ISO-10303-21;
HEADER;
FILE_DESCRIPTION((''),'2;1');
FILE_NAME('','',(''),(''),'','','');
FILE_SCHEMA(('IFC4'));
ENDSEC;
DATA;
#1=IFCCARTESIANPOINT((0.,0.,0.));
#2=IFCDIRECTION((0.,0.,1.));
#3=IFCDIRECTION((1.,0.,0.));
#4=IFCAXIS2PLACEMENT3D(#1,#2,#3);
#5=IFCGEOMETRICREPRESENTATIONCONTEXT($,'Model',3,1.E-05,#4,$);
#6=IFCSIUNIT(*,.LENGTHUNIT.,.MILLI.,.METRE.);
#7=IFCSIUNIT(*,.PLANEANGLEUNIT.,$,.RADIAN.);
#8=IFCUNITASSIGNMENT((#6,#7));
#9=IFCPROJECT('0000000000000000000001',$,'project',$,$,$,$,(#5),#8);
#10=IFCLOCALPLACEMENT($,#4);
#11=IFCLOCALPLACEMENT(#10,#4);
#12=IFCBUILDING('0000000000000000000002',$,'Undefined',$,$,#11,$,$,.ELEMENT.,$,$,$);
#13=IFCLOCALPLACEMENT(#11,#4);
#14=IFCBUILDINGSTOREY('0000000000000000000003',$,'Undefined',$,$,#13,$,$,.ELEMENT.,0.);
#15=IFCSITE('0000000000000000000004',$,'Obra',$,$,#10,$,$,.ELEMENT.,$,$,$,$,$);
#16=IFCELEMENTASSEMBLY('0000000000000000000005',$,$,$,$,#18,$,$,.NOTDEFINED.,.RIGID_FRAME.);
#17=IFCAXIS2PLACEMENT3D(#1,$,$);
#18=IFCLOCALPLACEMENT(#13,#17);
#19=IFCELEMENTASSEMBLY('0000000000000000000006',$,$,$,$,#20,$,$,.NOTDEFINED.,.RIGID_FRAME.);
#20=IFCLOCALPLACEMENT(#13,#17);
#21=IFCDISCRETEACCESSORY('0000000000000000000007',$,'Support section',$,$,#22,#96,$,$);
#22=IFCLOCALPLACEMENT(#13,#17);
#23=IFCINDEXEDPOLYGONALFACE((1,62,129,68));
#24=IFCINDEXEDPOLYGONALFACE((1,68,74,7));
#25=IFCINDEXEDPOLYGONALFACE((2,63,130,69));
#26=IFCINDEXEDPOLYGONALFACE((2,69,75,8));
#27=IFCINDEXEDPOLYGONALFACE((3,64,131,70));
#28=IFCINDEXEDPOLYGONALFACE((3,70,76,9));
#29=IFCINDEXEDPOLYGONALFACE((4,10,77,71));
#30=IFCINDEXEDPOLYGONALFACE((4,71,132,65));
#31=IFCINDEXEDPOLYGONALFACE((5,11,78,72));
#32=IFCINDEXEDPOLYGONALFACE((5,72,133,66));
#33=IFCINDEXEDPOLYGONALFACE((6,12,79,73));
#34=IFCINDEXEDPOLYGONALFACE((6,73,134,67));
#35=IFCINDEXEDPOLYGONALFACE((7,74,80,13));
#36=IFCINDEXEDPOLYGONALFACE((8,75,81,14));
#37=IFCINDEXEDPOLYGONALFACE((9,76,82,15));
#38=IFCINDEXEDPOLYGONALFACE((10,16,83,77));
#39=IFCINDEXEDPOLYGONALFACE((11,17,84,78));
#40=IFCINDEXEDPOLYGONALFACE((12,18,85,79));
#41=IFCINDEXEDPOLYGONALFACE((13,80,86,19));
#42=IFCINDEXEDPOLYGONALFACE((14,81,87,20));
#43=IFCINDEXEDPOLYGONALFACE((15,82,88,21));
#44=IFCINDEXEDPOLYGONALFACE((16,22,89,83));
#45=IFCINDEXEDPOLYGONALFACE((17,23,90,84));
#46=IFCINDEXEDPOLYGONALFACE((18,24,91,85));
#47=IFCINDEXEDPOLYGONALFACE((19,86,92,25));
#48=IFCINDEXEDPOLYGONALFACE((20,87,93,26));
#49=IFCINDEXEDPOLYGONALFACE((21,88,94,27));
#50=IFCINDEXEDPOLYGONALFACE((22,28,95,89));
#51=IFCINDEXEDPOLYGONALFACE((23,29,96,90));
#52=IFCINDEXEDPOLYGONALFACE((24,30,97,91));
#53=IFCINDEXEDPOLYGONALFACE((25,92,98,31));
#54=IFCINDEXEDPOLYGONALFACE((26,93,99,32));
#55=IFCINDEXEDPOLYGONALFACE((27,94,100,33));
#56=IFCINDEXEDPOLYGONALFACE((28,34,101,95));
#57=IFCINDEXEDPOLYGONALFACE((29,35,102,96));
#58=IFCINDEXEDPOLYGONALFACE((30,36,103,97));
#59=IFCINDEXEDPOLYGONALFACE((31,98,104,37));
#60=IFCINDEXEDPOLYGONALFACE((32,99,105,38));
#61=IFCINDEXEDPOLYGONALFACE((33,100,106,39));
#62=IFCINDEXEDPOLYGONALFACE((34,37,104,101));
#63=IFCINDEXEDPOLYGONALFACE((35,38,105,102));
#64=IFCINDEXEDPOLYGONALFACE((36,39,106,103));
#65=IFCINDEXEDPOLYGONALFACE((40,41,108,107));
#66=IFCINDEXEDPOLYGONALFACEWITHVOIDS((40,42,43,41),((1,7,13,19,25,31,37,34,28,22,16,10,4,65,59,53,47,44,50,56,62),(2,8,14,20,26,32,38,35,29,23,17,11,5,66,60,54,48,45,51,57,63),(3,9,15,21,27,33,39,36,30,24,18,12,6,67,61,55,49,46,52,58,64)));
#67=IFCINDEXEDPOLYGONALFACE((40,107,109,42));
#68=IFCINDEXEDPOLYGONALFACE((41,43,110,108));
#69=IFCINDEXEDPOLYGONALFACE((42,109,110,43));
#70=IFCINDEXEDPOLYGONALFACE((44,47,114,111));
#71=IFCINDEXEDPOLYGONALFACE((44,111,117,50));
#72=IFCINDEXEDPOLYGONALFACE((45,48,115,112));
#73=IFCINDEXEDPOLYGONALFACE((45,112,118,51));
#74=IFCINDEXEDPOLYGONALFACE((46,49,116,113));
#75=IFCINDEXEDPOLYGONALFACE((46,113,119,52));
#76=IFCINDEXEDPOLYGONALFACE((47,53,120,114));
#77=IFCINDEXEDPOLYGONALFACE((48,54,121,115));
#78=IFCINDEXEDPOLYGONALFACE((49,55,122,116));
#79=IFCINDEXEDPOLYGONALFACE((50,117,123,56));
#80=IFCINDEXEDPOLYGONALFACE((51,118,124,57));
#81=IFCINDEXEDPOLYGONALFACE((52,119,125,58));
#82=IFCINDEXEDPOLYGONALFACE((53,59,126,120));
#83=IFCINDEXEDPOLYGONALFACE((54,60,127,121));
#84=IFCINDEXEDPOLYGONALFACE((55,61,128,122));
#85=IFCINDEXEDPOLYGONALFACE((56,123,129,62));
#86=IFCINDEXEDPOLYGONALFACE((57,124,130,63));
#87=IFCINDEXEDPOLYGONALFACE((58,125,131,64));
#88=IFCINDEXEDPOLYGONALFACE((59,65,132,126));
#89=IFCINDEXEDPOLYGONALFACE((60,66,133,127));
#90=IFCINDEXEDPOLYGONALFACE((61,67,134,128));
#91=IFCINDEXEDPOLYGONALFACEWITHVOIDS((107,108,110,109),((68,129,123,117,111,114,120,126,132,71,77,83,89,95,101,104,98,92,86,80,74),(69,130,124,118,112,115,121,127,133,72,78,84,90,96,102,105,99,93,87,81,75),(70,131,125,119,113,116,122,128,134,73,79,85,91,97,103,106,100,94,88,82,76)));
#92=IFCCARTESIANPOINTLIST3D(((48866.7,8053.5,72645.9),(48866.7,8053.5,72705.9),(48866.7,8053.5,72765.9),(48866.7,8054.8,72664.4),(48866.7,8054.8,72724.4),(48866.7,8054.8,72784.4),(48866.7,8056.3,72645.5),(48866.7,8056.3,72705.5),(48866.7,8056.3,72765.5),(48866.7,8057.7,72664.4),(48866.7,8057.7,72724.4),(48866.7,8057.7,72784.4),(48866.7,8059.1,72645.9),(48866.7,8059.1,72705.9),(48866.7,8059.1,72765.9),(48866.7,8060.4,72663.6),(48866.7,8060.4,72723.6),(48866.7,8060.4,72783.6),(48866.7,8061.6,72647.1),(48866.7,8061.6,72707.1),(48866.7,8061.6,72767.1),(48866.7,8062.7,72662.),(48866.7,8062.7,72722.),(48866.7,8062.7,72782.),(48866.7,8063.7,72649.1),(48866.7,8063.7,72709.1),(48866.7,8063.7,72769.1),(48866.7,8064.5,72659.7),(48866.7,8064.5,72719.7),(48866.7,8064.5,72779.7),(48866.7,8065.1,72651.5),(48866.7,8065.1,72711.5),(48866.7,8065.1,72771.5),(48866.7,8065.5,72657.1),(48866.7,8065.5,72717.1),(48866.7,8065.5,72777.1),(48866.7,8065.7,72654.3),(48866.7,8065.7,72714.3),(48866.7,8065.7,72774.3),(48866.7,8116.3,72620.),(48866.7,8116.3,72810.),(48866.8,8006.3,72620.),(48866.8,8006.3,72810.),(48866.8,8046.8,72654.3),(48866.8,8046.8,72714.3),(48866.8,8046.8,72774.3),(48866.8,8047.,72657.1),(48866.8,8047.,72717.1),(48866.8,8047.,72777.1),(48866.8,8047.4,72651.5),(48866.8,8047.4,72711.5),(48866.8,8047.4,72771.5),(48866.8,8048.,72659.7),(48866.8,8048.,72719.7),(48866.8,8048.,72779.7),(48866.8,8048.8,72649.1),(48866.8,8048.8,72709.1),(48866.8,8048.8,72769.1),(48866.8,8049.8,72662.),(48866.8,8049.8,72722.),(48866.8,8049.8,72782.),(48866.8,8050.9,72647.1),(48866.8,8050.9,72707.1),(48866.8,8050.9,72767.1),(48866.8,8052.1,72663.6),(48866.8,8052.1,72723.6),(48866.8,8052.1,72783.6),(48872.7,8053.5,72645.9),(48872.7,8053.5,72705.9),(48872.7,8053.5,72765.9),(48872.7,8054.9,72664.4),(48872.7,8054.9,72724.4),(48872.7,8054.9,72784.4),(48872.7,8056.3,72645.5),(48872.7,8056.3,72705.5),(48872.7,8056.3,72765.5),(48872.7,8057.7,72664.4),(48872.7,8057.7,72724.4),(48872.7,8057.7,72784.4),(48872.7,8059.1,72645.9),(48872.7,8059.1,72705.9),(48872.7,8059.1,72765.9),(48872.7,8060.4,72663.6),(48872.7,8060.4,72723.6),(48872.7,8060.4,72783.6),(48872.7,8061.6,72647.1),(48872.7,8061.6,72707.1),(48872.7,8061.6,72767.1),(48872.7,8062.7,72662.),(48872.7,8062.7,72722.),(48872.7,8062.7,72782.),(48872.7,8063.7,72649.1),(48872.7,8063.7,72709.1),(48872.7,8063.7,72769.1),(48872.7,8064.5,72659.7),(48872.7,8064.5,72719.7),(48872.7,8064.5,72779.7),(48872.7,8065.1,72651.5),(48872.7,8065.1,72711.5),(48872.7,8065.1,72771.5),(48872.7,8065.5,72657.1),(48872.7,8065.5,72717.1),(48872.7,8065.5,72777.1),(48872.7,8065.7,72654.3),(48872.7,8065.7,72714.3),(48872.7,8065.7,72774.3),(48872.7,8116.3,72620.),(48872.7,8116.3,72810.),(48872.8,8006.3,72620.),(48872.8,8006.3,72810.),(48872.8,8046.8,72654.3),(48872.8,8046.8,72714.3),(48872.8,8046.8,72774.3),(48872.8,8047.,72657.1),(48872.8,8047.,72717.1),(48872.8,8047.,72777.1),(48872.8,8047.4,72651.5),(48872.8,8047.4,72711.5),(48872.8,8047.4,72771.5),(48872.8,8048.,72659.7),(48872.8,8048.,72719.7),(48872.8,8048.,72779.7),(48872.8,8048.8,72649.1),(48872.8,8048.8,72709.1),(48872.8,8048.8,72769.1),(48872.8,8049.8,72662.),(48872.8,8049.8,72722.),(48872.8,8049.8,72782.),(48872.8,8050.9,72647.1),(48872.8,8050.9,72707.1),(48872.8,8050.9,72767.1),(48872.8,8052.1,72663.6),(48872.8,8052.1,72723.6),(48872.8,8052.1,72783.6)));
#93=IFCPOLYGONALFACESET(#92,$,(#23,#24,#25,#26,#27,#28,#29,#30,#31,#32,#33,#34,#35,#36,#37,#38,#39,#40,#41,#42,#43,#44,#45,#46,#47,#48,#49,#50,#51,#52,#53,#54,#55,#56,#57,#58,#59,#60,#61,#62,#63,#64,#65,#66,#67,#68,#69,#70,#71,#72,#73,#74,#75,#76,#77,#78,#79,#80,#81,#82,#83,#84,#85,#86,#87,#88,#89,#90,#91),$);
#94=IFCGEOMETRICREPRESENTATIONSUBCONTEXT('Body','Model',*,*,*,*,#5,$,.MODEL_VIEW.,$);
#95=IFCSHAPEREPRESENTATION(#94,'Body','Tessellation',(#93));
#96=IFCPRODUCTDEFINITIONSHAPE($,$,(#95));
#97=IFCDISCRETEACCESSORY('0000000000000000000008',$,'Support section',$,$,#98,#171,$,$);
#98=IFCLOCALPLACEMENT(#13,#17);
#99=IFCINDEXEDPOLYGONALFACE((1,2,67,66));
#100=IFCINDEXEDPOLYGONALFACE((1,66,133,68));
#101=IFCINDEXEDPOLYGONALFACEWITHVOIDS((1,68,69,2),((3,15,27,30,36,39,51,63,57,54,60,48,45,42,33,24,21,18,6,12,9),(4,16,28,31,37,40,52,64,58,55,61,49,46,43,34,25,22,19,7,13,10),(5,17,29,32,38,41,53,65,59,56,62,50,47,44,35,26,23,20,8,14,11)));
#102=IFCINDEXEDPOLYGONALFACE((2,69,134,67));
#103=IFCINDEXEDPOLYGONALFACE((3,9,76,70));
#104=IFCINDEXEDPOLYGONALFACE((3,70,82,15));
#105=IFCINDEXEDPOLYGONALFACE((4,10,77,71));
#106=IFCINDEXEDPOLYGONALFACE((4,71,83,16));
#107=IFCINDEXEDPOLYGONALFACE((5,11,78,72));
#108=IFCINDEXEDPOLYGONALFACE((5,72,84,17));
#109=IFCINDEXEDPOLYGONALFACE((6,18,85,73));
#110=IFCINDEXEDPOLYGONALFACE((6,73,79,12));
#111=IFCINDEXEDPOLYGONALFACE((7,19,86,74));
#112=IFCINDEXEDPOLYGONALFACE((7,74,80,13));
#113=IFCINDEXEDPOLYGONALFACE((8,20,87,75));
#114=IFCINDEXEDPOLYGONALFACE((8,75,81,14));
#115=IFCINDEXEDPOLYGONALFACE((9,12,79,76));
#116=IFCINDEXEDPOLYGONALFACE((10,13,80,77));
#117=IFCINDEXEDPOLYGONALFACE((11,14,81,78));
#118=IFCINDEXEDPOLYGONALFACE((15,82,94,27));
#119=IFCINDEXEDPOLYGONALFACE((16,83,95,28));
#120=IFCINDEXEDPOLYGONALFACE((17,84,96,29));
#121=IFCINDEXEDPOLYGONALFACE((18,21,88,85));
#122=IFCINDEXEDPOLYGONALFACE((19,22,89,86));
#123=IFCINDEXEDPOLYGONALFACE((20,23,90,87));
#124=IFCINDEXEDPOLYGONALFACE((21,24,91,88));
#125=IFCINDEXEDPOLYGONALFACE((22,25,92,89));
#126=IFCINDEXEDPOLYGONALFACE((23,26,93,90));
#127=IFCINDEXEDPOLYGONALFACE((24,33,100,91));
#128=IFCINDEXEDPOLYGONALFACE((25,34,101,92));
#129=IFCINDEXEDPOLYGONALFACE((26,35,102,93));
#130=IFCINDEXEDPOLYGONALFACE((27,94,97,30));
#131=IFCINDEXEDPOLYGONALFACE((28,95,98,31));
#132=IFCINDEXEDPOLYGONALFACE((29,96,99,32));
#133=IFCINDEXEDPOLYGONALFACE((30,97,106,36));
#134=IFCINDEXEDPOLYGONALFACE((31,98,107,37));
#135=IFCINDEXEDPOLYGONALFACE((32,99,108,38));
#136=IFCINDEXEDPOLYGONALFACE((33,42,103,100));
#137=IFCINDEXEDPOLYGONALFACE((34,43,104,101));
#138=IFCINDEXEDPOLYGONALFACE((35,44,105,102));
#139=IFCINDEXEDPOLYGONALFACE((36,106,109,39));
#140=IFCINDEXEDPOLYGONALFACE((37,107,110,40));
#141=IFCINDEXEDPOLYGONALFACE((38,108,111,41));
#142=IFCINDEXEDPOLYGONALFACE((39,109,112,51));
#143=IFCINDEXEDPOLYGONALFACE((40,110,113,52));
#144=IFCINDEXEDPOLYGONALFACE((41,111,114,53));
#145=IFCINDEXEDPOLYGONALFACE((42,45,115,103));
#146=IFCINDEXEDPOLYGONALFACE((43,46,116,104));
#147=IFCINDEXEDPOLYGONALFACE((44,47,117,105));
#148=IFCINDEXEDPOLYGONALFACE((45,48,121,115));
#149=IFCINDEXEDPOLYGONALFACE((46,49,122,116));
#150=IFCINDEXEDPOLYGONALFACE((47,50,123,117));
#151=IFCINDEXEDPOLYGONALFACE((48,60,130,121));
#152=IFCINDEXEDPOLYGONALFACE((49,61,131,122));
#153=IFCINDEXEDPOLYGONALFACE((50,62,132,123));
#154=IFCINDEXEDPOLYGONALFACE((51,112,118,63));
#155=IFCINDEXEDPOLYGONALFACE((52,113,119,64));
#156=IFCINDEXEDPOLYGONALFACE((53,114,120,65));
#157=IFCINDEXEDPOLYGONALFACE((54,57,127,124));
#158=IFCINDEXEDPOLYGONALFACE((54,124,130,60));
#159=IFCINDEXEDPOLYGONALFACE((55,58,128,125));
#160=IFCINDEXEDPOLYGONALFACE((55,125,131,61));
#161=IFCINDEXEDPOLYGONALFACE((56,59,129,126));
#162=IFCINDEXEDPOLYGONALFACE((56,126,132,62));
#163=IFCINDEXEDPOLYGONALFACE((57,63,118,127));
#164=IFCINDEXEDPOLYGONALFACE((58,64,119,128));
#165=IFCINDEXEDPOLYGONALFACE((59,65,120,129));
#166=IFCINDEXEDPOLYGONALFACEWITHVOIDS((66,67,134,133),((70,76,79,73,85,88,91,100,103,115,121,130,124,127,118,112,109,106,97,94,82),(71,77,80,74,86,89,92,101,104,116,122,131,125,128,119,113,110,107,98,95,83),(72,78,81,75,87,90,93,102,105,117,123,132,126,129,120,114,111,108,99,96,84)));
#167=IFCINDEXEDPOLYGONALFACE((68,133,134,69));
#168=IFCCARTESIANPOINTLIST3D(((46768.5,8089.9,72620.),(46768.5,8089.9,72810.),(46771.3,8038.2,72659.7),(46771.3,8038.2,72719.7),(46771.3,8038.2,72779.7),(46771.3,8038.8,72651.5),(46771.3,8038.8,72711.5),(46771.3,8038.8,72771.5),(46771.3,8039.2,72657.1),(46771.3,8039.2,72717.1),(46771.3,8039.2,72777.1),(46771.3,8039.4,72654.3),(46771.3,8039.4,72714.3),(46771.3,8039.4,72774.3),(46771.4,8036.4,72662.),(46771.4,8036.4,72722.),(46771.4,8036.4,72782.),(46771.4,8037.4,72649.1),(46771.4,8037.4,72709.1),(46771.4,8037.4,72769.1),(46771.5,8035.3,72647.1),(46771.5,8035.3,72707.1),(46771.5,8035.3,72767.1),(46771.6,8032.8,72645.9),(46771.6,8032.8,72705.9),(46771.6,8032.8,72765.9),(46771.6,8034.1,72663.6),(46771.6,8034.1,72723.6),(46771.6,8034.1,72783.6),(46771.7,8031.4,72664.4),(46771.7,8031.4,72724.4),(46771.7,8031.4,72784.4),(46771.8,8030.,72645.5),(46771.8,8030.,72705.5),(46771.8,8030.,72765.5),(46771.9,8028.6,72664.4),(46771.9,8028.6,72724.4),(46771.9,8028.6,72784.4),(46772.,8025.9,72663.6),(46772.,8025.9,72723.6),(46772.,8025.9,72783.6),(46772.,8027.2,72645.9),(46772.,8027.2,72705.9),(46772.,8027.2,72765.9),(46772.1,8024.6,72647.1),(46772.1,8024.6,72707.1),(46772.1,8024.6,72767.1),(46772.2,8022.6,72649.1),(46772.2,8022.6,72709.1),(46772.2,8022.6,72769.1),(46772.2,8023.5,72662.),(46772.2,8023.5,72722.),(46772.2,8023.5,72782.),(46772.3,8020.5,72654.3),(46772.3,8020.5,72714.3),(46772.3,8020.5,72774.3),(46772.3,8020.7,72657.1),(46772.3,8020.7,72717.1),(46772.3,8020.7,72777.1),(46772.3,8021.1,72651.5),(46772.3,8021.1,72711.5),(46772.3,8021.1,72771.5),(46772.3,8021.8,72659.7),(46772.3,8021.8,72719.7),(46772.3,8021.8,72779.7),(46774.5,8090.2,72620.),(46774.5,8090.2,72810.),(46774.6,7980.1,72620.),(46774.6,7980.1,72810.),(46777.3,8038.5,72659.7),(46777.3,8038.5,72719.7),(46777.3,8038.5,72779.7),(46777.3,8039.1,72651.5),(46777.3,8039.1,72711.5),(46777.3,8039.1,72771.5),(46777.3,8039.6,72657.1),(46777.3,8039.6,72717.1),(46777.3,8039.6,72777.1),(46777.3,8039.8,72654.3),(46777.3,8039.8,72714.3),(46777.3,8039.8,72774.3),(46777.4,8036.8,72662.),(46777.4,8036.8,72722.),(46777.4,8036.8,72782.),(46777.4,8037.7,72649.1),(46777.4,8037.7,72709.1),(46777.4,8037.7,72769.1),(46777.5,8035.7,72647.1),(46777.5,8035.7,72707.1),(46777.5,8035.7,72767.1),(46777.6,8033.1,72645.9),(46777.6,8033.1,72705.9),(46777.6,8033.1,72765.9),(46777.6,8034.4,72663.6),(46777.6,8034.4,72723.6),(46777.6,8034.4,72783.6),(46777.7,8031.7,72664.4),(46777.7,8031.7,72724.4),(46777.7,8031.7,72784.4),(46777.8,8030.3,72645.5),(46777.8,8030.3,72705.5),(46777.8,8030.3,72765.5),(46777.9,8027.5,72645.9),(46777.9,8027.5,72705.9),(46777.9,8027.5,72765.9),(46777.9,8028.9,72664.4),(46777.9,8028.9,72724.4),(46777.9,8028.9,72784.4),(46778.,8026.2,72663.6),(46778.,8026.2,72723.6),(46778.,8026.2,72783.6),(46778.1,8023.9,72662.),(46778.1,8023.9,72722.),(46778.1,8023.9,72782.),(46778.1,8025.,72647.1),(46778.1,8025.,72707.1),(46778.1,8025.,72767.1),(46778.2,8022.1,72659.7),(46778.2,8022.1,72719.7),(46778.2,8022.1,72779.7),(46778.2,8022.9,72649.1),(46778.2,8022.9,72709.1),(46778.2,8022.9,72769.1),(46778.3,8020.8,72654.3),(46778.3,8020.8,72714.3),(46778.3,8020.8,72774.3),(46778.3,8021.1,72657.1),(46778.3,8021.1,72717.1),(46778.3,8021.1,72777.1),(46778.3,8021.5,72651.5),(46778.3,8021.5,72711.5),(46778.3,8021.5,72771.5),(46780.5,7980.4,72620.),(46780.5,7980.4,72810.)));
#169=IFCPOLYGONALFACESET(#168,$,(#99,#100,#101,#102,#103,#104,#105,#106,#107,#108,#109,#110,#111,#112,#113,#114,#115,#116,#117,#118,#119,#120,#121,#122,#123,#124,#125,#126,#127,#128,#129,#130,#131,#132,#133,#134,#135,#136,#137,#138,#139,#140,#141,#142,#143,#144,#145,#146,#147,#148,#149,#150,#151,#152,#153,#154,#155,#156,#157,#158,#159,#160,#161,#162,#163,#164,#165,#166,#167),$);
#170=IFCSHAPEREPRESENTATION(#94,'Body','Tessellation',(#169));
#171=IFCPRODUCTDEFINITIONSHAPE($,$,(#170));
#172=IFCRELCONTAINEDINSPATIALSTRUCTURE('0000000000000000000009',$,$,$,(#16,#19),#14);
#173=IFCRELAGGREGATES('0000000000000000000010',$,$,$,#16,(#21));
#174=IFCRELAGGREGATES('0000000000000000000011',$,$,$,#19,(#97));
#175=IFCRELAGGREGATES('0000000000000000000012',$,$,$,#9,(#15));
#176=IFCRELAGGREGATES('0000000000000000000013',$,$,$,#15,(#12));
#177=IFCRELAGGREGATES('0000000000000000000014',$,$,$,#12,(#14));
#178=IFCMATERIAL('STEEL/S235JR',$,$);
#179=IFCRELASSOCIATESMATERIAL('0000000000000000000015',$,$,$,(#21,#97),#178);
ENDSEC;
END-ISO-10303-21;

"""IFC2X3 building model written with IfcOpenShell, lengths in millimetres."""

from ifc_helpers import new_model, si_unit, frame, origin_with_axes, origin_2d_with_axis, place, context, subcontext, project, spatial, rectangle, circle, extrude, source, transform, mapped, material, element, aggregate, save


model = new_model("IFC2X3")

# Units and contexts
model_context = context("Model", 3, precision=1e-05, world=origin_with_axes())
body_context = subcontext(model_context, "Body", "Model", "MODEL_VIEW")
ifc_project = project(units=[si_unit("LENGTHUNIT", "METRE", prefix="MILLI"), si_unit("PLANEANGLEUNIT", "RADIAN")], contexts=[model_context])

# Site, building, storey
site_placement = place(None, origin_with_axes())
site = spatial("IfcSite", under=ifc_project, at=site_placement, Name="Obra", CompositionType="ELEMENT")
building_placement = place(site_placement, origin_with_axes())
building = spatial("IfcBuilding", under=site, at=building_placement, Name="Undefined", CompositionType="ELEMENT")
storey_placement = place(building_placement, origin_with_axes())
storey = spatial("IfcBuildingStorey", under=building, at=storey_placement, Name="Undefined", CompositionType="ELEMENT", Elevation=0.0)

# Element assemblies
ifc_material_1 = material(Name="STEEL/S235JR")
assembly_1_placement = place(storey_placement, origin_with_axes())
assembly_1 = element("IfcElementAssembly", 1, at=assembly_1_placement, inside=storey, AssemblyPlace="NOTDEFINED", PredefinedType="RIGID_FRAME")
assembly_2_placement = place(storey_placement, origin_with_axes())
assembly_2 = element("IfcElementAssembly", 2, at=assembly_2_placement, inside=storey, AssemblyPlace="NOTDEFINED", PredefinedType="RIGID_FRAME")

# Shared definitions
shared_shape = source(origin_with_axes(), body_context, "Body", "SweptSolid", [
    extrude(circle(Radius=9.5, at=origin_2d_with_axis()), frame((0.0, -9.2, 0.0), z_axis=(0.0, 1.0, 0.0), x_axis=(1.0, 0.0, 0.0)), (0.0, 0.0, 1.0), 6.2),
])

# Discrete accessories, openings
discrete_accessory_1_placement = place(assembly_1_placement, frame((48869.7, 8061.3, 72620.0), z_axis=(0.0, 0.0, 1.0), x_axis=(-0.001508, 0.999999, 0.0)))
discrete_accessory_1 = element("IfcDiscreteAccessory", 3, at=discrete_accessory_1_placement, material=ifc_material_1, Name="Support section", context=body_context, shape_type="SweptSolid", body=[
    extrude(rectangle(XDim=6.0, YDim=110.0, at=origin_2d_with_axis()), frame((0.0, 0.0, 190.0), z_axis=(0.0, 0.0, -1.0), x_axis=(0.0, 1.0, 0.0)), (0.0, 0.0, 1.0), 190.0),
])
opening_1_placement = place(assembly_1_placement, frame((48875.8, 8106.3, 72835.0), z_axis=(0.001508, -0.999999, 0.0), x_axis=(0.0, 0.0, -1.0)))
element("IfcOpeningElement", 4, at=opening_1_placement, cuts=discrete_accessory_1, ObjectType="Opening", context=body_context, shape_type="MappedRepresentation", body=[
    mapped(shared_shape, transform((60.0, 0.0, 50.0))),
    mapped(shared_shape, transform((120.0, 0.0, 50.0))),
    mapped(shared_shape, transform((180.0, 0.0, 50.0))),
])
aggregate(assembly_1, [discrete_accessory_1])
discrete_accessory_2_placement = place(assembly_2_placement, frame((46774.5, 8035.1, 72620.0), z_axis=(0.0, 0.0, 1.0), x_axis=(-0.055152, 0.998478, 0.0)))
discrete_accessory_2 = element("IfcDiscreteAccessory", 5, at=discrete_accessory_2_placement, material=ifc_material_1, Name="Support section", context=body_context, shape_type="SweptSolid", body=[
    extrude(rectangle(XDim=6.0, YDim=110.0, at=origin_2d_with_axis()), frame((0.0, 0.0, 190.0), z_axis=(0.0, 0.0, -1.0), x_axis=(0.0, 1.0, 0.0)), (0.0, 0.0, 1.0), 190.0),
])
opening_2_placement = place(assembly_2_placement, frame((46778.1, 8080.4, 72835.0), z_axis=(0.055152, -0.998478, 0.0), x_axis=(0.0, 0.0, -1.0)))
element("IfcOpeningElement", 6, at=opening_2_placement, cuts=discrete_accessory_2, ObjectType="Opening", context=body_context, shape_type="MappedRepresentation", body=[
    mapped(shared_shape, transform((60.0, 0.0, 50.0))),
    mapped(shared_shape, transform((120.0, 0.0, 50.0))),
    mapped(shared_shape, transform((180.0, 0.0, 50.0))),
])
aggregate(assembly_2, [discrete_accessory_2])

save(model, "model.ifc")
